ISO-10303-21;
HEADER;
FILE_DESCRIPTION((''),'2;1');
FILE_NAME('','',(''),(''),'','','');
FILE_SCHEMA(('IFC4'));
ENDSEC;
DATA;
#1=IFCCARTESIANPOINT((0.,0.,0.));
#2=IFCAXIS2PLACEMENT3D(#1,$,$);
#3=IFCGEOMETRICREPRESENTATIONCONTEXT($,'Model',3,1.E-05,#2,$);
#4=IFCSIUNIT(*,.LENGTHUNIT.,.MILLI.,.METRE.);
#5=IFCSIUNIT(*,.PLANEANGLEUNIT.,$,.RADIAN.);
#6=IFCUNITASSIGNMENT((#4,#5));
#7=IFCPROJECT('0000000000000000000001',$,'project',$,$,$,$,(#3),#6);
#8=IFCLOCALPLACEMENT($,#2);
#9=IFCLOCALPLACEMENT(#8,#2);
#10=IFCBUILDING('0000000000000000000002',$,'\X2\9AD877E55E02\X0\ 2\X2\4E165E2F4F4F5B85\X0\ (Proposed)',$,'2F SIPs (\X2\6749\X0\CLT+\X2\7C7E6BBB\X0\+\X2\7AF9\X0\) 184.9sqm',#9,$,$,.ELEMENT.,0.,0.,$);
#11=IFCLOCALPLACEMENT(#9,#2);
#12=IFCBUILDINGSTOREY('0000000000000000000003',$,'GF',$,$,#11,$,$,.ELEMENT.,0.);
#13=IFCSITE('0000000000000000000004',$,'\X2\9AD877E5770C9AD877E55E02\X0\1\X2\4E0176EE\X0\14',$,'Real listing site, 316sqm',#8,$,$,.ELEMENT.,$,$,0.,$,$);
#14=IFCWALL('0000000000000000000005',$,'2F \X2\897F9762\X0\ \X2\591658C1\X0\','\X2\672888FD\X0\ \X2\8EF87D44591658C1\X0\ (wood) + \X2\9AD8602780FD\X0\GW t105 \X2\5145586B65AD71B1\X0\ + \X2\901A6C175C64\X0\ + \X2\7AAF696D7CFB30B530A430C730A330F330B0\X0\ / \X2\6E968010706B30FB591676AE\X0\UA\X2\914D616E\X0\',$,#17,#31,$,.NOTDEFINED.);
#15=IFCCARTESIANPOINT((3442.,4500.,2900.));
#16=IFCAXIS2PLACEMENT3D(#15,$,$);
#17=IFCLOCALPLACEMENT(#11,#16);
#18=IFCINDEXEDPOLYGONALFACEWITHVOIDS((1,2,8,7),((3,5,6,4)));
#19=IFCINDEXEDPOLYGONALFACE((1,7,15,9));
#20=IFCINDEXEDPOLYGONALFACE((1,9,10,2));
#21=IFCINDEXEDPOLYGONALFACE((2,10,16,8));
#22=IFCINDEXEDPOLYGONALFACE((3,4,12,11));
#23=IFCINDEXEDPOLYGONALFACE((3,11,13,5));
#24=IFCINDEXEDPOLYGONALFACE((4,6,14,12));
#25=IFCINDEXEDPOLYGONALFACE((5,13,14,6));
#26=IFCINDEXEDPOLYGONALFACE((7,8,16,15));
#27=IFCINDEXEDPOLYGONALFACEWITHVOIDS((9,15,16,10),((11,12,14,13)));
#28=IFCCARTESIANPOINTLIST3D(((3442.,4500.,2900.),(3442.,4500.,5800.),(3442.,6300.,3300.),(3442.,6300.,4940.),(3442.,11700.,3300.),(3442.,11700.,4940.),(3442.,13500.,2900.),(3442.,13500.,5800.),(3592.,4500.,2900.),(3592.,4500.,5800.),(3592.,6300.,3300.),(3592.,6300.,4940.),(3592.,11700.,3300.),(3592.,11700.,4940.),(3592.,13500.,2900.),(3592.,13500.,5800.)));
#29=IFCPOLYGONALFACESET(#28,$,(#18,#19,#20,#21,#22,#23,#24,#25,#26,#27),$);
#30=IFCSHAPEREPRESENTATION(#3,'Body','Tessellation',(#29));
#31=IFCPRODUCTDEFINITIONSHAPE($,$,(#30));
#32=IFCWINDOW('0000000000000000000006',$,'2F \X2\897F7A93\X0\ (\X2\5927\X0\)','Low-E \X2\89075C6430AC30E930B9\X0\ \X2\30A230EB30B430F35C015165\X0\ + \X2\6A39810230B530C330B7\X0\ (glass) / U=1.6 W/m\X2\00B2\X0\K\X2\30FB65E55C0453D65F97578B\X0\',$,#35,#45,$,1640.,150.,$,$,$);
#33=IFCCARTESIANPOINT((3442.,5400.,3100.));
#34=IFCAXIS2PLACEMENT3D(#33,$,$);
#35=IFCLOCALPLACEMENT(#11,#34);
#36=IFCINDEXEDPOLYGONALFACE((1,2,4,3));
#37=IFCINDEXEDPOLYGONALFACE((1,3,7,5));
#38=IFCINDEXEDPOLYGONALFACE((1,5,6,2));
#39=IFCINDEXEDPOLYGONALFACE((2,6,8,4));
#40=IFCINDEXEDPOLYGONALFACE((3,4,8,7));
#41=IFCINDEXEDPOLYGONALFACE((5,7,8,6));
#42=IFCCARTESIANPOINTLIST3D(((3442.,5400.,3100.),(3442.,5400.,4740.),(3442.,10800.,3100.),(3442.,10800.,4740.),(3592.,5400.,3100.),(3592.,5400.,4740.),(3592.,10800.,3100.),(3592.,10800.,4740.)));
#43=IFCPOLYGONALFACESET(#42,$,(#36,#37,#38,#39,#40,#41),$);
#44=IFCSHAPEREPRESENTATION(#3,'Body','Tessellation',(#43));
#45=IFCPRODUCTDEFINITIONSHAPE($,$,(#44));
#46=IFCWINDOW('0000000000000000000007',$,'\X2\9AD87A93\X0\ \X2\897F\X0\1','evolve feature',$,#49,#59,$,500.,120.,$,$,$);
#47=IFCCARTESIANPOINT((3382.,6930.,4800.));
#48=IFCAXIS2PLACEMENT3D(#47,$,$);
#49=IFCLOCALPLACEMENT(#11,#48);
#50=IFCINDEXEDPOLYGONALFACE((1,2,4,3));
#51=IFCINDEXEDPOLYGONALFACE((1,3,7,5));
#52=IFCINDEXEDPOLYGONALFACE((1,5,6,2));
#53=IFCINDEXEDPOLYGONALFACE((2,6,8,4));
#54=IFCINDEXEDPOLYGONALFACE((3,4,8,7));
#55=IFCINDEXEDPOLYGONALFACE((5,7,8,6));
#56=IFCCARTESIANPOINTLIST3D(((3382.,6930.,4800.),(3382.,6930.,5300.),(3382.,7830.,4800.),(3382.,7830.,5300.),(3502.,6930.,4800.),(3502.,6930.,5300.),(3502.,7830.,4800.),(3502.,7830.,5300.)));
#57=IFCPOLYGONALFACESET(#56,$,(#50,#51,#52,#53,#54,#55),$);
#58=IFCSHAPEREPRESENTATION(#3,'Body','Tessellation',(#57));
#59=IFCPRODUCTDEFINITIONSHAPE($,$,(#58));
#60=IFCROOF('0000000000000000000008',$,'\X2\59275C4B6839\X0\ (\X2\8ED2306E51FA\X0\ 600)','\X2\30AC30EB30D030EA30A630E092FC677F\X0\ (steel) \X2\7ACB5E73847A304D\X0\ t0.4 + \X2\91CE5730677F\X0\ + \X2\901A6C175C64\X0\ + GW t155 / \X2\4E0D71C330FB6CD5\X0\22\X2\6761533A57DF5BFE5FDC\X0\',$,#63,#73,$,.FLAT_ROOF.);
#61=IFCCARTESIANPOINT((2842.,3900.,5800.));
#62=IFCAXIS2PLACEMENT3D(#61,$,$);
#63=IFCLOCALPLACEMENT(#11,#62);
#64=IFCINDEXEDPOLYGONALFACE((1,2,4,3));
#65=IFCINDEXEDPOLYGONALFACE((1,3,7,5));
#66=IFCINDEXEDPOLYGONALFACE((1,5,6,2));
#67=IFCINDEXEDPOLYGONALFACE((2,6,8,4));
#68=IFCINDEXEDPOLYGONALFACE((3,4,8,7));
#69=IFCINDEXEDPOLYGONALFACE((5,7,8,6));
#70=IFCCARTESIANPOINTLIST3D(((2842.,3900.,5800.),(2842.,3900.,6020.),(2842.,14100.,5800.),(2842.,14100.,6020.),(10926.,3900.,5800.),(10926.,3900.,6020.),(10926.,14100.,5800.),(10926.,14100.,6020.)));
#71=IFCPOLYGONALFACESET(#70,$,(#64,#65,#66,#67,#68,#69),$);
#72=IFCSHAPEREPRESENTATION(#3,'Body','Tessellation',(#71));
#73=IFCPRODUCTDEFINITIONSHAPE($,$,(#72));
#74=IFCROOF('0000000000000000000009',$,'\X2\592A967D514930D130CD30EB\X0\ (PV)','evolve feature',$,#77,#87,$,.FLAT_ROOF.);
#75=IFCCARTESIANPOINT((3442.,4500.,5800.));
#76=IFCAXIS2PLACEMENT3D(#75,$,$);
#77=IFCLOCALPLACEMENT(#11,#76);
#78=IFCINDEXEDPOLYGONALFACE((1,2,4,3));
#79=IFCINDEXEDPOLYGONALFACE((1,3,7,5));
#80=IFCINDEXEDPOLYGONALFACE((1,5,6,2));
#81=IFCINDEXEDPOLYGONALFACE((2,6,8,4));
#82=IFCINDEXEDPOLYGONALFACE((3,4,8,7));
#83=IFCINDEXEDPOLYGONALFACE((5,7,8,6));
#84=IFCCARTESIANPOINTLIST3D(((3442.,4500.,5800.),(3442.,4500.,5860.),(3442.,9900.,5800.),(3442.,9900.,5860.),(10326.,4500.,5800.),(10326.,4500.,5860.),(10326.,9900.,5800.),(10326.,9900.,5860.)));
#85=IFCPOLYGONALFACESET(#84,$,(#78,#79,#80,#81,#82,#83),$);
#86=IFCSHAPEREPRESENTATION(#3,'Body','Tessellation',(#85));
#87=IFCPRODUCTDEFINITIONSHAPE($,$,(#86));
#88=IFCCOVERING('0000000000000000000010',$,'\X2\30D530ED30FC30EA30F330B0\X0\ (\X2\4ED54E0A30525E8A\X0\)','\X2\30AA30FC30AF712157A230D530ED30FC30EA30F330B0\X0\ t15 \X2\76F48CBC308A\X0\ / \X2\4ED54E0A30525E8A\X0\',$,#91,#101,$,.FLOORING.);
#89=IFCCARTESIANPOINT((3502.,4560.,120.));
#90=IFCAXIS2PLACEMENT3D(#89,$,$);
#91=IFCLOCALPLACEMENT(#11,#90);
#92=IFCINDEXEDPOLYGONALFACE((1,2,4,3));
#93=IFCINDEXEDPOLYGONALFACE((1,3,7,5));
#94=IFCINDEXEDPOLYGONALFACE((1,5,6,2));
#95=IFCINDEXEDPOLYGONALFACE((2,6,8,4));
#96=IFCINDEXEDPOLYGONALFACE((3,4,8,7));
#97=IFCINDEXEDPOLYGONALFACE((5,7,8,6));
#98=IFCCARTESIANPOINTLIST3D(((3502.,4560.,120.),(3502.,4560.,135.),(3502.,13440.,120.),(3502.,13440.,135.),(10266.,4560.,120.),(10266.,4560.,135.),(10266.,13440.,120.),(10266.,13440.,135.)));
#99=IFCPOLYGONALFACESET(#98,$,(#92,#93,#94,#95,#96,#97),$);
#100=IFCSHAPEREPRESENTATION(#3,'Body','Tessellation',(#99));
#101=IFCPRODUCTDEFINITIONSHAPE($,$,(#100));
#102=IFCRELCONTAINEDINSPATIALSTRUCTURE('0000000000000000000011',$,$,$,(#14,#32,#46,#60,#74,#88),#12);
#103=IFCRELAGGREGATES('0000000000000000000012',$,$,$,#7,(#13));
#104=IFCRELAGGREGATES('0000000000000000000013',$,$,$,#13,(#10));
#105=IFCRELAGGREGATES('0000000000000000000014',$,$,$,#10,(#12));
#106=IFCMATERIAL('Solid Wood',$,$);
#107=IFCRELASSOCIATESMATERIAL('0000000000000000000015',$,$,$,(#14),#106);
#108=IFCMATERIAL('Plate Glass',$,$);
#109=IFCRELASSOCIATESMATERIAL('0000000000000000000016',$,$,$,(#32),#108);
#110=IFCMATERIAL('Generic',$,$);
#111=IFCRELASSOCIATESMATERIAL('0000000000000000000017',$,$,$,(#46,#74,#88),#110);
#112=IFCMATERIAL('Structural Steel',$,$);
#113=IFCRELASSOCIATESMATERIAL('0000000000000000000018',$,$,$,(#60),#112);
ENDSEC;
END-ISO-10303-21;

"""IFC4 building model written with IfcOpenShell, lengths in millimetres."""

from ifc_helpers import new_model, si_unit, frame, frame_2d, origin, place, context, project, spatial, rectangle, extrude, material, element, fill, save


model = new_model("IFC4")

# Units and contexts
model_context = context("Model", 3, precision=1e-05, world=origin())
ifc_project = project(units=[si_unit("LENGTHUNIT", "METRE", prefix="MILLI"), si_unit("PLANEANGLEUNIT", "RADIAN")], contexts=[model_context])

# Site, building, storey
site_placement = place(None, origin())
site = spatial("IfcSite", under=ifc_project, at=site_placement, Name="高知県高知市1丁目14", ObjectType="Real listing site, 316sqm", CompositionType="ELEMENT", RefElevation=0.0)
building_placement = place(site_placement, origin())
building = spatial("IfcBuilding", under=site, at=building_placement, Name="高知市 2世帯住宅 (Proposed)", ObjectType="2F SIPs (杉CLT+籾殻+竹) 184.9sqm", CompositionType="ELEMENT", ElevationOfRefHeight=0.0, ElevationOfTerrain=0.0)
storey_placement = place(building_placement, origin())
storey = spatial("IfcBuildingStorey", under=building, at=storey_placement, Name="GF", CompositionType="ELEMENT", Elevation=0.0)

# Shared definitions
ifc_material_1 = material(Name="Solid Wood")

# Shared definitions
ifc_material_2 = material(Name="Plate Glass")
ifc_material_3 = material(Name="Generic")

# Wall, openings, windows
wall_1_placement = place(storey_placement, frame((3442.0, 4500.0, 2900.0)))
wall_1 = element("IfcWall", 1, at=wall_1_placement, inside=storey, material=ifc_material_1, Name="2F 西面 外壁", Description="木製 軸組外壁 (wood) + 高性能GW t105 充填断熱 + 通気層 + 窯業系サイディング / 準耐火・外皮UA配慮", PredefinedType="NOTDEFINED", context=model_context, shape_type="SweptSolid", body=[
    extrude(rectangle(XDim=150.0, YDim=9000.0, at=frame_2d((75.0, 4500.0))), frame((3442.0, 4500.0, 2900.0)), (0.0, 0.0, 1.0), 2900.0),
])
opening_1_placement = place(storey_placement, frame((3442.0, 5400.0, 3100.0)))
opening_1 = element("IfcOpeningElement", 2, at=opening_1_placement, cuts=wall_1, PredefinedType="NOTDEFINED", context=model_context, shape_type="SweptSolid", body=[
    extrude(rectangle(XDim=150.0, YDim=5400.0, at=frame_2d((75.0, 2700.0))), frame((3442.0, 5400.0, 3100.0)), (0.0, 0.0, 1.0), 1640.0),
])
opening_2_placement = place(storey_placement, frame((3382.0, 6930.0, 4800.0)))
opening_2 = element("IfcOpeningElement", 3, at=opening_2_placement, cuts=wall_1, PredefinedType="NOTDEFINED", context=model_context, shape_type="SweptSolid", body=[
    extrude(rectangle(XDim=120.0, YDim=900.0, at=frame_2d((60.0, 450.0))), frame((3382.0, 6930.0, 4800.0)), (0.0, 0.0, 1.0), 500.0),
])
window_1_placement = place(storey_placement, frame((3442.0, 5400.0, 3100.0)))
window_1 = element("IfcWindow", 4, at=window_1_placement, inside=storey, material=ifc_material_2, Name="2F 西窓 (大)", Description="Low-E 複層ガラス アルゴン封入 + 樹脂サッシ (glass) / U=1.6 W/m²K・日射取得型", OverallHeight=1640.0, OverallWidth=150.0, context=model_context, shape_type="SweptSolid", body=[
    extrude(rectangle(XDim=150.0, YDim=5400.0, at=frame_2d((75.0, 2700.0))), frame((3442.0, 5400.0, 3100.0)), (0.0, 0.0, 1.0), 1640.0),
])
fill(opening_1, window_1)
window_2_placement = place(storey_placement, frame((3382.0, 6930.0, 4800.0)))
window_2 = element("IfcWindow", 5, at=window_2_placement, inside=storey, material=ifc_material_3, Name="高窓 西1", Description="evolve feature", OverallHeight=500.0, OverallWidth=120.0, context=model_context, shape_type="SweptSolid", body=[
    extrude(rectangle(XDim=120.0, YDim=900.0, at=frame_2d((60.0, 450.0))), frame((3382.0, 6930.0, 4800.0)), (0.0, 0.0, 1.0), 500.0),
])
fill(opening_2, window_2)

# Roofs
ifc_material_4 = material(Name="Structural Steel")
roof_1_placement = place(storey_placement, frame((2842.0, 3900.0, 5800.0)))
element("IfcRoof", 6, at=roof_1_placement, inside=storey, material=ifc_material_4, Name="大屋根 (軒の出 600)", Description="ガルバリウム鋼板 (steel) 立平葺き t0.4 + 野地板 + 通気層 + GW t155 / 不燃・法22条区域対応", PredefinedType="FLAT_ROOF", context=model_context, shape_type="SweptSolid", body=[
    extrude(rectangle(XDim=8084.0, YDim=10200.0, at=frame_2d((4042.0, 5100.0))), frame((2842.0, 3900.0, 5800.0)), (0.0, 0.0, 1.0), 220.0),
])
roof_2_placement = place(storey_placement, frame((3442.0, 4500.0, 5800.0)))
element("IfcRoof", 7, at=roof_2_placement, inside=storey, material=ifc_material_3, Name="太陽光パネル (PV)", Description="evolve feature", PredefinedType="FLAT_ROOF", context=model_context, shape_type="SweptSolid", body=[
    extrude(rectangle(XDim=6884.0, YDim=5400.0, at=frame_2d((3442.0, 2700.0))), frame((3442.0, 4500.0, 5800.0)), (0.0, 0.0, 1.0), 60.0),
])

# Covering
covering_placement = place(storey_placement, frame((3502.0, 4560.0, 120.0)))
element("IfcCovering", 8, at=covering_placement, inside=storey, material=ifc_material_3, Name="フローリング (仕上げ床)", Description="オーク無垢フローリング t15 直貼り / 仕上げ床", PredefinedType="FLOORING", context=model_context, shape_type="SweptSolid", body=[
    extrude(rectangle(XDim=6764.0, YDim=8880.0, at=frame_2d((3382.0, 4440.0))), frame((3502.0, 4560.0, 120.0)), (0.0, 0.0, 1.0), 15.0),
])

save(model, "model.ifc")
